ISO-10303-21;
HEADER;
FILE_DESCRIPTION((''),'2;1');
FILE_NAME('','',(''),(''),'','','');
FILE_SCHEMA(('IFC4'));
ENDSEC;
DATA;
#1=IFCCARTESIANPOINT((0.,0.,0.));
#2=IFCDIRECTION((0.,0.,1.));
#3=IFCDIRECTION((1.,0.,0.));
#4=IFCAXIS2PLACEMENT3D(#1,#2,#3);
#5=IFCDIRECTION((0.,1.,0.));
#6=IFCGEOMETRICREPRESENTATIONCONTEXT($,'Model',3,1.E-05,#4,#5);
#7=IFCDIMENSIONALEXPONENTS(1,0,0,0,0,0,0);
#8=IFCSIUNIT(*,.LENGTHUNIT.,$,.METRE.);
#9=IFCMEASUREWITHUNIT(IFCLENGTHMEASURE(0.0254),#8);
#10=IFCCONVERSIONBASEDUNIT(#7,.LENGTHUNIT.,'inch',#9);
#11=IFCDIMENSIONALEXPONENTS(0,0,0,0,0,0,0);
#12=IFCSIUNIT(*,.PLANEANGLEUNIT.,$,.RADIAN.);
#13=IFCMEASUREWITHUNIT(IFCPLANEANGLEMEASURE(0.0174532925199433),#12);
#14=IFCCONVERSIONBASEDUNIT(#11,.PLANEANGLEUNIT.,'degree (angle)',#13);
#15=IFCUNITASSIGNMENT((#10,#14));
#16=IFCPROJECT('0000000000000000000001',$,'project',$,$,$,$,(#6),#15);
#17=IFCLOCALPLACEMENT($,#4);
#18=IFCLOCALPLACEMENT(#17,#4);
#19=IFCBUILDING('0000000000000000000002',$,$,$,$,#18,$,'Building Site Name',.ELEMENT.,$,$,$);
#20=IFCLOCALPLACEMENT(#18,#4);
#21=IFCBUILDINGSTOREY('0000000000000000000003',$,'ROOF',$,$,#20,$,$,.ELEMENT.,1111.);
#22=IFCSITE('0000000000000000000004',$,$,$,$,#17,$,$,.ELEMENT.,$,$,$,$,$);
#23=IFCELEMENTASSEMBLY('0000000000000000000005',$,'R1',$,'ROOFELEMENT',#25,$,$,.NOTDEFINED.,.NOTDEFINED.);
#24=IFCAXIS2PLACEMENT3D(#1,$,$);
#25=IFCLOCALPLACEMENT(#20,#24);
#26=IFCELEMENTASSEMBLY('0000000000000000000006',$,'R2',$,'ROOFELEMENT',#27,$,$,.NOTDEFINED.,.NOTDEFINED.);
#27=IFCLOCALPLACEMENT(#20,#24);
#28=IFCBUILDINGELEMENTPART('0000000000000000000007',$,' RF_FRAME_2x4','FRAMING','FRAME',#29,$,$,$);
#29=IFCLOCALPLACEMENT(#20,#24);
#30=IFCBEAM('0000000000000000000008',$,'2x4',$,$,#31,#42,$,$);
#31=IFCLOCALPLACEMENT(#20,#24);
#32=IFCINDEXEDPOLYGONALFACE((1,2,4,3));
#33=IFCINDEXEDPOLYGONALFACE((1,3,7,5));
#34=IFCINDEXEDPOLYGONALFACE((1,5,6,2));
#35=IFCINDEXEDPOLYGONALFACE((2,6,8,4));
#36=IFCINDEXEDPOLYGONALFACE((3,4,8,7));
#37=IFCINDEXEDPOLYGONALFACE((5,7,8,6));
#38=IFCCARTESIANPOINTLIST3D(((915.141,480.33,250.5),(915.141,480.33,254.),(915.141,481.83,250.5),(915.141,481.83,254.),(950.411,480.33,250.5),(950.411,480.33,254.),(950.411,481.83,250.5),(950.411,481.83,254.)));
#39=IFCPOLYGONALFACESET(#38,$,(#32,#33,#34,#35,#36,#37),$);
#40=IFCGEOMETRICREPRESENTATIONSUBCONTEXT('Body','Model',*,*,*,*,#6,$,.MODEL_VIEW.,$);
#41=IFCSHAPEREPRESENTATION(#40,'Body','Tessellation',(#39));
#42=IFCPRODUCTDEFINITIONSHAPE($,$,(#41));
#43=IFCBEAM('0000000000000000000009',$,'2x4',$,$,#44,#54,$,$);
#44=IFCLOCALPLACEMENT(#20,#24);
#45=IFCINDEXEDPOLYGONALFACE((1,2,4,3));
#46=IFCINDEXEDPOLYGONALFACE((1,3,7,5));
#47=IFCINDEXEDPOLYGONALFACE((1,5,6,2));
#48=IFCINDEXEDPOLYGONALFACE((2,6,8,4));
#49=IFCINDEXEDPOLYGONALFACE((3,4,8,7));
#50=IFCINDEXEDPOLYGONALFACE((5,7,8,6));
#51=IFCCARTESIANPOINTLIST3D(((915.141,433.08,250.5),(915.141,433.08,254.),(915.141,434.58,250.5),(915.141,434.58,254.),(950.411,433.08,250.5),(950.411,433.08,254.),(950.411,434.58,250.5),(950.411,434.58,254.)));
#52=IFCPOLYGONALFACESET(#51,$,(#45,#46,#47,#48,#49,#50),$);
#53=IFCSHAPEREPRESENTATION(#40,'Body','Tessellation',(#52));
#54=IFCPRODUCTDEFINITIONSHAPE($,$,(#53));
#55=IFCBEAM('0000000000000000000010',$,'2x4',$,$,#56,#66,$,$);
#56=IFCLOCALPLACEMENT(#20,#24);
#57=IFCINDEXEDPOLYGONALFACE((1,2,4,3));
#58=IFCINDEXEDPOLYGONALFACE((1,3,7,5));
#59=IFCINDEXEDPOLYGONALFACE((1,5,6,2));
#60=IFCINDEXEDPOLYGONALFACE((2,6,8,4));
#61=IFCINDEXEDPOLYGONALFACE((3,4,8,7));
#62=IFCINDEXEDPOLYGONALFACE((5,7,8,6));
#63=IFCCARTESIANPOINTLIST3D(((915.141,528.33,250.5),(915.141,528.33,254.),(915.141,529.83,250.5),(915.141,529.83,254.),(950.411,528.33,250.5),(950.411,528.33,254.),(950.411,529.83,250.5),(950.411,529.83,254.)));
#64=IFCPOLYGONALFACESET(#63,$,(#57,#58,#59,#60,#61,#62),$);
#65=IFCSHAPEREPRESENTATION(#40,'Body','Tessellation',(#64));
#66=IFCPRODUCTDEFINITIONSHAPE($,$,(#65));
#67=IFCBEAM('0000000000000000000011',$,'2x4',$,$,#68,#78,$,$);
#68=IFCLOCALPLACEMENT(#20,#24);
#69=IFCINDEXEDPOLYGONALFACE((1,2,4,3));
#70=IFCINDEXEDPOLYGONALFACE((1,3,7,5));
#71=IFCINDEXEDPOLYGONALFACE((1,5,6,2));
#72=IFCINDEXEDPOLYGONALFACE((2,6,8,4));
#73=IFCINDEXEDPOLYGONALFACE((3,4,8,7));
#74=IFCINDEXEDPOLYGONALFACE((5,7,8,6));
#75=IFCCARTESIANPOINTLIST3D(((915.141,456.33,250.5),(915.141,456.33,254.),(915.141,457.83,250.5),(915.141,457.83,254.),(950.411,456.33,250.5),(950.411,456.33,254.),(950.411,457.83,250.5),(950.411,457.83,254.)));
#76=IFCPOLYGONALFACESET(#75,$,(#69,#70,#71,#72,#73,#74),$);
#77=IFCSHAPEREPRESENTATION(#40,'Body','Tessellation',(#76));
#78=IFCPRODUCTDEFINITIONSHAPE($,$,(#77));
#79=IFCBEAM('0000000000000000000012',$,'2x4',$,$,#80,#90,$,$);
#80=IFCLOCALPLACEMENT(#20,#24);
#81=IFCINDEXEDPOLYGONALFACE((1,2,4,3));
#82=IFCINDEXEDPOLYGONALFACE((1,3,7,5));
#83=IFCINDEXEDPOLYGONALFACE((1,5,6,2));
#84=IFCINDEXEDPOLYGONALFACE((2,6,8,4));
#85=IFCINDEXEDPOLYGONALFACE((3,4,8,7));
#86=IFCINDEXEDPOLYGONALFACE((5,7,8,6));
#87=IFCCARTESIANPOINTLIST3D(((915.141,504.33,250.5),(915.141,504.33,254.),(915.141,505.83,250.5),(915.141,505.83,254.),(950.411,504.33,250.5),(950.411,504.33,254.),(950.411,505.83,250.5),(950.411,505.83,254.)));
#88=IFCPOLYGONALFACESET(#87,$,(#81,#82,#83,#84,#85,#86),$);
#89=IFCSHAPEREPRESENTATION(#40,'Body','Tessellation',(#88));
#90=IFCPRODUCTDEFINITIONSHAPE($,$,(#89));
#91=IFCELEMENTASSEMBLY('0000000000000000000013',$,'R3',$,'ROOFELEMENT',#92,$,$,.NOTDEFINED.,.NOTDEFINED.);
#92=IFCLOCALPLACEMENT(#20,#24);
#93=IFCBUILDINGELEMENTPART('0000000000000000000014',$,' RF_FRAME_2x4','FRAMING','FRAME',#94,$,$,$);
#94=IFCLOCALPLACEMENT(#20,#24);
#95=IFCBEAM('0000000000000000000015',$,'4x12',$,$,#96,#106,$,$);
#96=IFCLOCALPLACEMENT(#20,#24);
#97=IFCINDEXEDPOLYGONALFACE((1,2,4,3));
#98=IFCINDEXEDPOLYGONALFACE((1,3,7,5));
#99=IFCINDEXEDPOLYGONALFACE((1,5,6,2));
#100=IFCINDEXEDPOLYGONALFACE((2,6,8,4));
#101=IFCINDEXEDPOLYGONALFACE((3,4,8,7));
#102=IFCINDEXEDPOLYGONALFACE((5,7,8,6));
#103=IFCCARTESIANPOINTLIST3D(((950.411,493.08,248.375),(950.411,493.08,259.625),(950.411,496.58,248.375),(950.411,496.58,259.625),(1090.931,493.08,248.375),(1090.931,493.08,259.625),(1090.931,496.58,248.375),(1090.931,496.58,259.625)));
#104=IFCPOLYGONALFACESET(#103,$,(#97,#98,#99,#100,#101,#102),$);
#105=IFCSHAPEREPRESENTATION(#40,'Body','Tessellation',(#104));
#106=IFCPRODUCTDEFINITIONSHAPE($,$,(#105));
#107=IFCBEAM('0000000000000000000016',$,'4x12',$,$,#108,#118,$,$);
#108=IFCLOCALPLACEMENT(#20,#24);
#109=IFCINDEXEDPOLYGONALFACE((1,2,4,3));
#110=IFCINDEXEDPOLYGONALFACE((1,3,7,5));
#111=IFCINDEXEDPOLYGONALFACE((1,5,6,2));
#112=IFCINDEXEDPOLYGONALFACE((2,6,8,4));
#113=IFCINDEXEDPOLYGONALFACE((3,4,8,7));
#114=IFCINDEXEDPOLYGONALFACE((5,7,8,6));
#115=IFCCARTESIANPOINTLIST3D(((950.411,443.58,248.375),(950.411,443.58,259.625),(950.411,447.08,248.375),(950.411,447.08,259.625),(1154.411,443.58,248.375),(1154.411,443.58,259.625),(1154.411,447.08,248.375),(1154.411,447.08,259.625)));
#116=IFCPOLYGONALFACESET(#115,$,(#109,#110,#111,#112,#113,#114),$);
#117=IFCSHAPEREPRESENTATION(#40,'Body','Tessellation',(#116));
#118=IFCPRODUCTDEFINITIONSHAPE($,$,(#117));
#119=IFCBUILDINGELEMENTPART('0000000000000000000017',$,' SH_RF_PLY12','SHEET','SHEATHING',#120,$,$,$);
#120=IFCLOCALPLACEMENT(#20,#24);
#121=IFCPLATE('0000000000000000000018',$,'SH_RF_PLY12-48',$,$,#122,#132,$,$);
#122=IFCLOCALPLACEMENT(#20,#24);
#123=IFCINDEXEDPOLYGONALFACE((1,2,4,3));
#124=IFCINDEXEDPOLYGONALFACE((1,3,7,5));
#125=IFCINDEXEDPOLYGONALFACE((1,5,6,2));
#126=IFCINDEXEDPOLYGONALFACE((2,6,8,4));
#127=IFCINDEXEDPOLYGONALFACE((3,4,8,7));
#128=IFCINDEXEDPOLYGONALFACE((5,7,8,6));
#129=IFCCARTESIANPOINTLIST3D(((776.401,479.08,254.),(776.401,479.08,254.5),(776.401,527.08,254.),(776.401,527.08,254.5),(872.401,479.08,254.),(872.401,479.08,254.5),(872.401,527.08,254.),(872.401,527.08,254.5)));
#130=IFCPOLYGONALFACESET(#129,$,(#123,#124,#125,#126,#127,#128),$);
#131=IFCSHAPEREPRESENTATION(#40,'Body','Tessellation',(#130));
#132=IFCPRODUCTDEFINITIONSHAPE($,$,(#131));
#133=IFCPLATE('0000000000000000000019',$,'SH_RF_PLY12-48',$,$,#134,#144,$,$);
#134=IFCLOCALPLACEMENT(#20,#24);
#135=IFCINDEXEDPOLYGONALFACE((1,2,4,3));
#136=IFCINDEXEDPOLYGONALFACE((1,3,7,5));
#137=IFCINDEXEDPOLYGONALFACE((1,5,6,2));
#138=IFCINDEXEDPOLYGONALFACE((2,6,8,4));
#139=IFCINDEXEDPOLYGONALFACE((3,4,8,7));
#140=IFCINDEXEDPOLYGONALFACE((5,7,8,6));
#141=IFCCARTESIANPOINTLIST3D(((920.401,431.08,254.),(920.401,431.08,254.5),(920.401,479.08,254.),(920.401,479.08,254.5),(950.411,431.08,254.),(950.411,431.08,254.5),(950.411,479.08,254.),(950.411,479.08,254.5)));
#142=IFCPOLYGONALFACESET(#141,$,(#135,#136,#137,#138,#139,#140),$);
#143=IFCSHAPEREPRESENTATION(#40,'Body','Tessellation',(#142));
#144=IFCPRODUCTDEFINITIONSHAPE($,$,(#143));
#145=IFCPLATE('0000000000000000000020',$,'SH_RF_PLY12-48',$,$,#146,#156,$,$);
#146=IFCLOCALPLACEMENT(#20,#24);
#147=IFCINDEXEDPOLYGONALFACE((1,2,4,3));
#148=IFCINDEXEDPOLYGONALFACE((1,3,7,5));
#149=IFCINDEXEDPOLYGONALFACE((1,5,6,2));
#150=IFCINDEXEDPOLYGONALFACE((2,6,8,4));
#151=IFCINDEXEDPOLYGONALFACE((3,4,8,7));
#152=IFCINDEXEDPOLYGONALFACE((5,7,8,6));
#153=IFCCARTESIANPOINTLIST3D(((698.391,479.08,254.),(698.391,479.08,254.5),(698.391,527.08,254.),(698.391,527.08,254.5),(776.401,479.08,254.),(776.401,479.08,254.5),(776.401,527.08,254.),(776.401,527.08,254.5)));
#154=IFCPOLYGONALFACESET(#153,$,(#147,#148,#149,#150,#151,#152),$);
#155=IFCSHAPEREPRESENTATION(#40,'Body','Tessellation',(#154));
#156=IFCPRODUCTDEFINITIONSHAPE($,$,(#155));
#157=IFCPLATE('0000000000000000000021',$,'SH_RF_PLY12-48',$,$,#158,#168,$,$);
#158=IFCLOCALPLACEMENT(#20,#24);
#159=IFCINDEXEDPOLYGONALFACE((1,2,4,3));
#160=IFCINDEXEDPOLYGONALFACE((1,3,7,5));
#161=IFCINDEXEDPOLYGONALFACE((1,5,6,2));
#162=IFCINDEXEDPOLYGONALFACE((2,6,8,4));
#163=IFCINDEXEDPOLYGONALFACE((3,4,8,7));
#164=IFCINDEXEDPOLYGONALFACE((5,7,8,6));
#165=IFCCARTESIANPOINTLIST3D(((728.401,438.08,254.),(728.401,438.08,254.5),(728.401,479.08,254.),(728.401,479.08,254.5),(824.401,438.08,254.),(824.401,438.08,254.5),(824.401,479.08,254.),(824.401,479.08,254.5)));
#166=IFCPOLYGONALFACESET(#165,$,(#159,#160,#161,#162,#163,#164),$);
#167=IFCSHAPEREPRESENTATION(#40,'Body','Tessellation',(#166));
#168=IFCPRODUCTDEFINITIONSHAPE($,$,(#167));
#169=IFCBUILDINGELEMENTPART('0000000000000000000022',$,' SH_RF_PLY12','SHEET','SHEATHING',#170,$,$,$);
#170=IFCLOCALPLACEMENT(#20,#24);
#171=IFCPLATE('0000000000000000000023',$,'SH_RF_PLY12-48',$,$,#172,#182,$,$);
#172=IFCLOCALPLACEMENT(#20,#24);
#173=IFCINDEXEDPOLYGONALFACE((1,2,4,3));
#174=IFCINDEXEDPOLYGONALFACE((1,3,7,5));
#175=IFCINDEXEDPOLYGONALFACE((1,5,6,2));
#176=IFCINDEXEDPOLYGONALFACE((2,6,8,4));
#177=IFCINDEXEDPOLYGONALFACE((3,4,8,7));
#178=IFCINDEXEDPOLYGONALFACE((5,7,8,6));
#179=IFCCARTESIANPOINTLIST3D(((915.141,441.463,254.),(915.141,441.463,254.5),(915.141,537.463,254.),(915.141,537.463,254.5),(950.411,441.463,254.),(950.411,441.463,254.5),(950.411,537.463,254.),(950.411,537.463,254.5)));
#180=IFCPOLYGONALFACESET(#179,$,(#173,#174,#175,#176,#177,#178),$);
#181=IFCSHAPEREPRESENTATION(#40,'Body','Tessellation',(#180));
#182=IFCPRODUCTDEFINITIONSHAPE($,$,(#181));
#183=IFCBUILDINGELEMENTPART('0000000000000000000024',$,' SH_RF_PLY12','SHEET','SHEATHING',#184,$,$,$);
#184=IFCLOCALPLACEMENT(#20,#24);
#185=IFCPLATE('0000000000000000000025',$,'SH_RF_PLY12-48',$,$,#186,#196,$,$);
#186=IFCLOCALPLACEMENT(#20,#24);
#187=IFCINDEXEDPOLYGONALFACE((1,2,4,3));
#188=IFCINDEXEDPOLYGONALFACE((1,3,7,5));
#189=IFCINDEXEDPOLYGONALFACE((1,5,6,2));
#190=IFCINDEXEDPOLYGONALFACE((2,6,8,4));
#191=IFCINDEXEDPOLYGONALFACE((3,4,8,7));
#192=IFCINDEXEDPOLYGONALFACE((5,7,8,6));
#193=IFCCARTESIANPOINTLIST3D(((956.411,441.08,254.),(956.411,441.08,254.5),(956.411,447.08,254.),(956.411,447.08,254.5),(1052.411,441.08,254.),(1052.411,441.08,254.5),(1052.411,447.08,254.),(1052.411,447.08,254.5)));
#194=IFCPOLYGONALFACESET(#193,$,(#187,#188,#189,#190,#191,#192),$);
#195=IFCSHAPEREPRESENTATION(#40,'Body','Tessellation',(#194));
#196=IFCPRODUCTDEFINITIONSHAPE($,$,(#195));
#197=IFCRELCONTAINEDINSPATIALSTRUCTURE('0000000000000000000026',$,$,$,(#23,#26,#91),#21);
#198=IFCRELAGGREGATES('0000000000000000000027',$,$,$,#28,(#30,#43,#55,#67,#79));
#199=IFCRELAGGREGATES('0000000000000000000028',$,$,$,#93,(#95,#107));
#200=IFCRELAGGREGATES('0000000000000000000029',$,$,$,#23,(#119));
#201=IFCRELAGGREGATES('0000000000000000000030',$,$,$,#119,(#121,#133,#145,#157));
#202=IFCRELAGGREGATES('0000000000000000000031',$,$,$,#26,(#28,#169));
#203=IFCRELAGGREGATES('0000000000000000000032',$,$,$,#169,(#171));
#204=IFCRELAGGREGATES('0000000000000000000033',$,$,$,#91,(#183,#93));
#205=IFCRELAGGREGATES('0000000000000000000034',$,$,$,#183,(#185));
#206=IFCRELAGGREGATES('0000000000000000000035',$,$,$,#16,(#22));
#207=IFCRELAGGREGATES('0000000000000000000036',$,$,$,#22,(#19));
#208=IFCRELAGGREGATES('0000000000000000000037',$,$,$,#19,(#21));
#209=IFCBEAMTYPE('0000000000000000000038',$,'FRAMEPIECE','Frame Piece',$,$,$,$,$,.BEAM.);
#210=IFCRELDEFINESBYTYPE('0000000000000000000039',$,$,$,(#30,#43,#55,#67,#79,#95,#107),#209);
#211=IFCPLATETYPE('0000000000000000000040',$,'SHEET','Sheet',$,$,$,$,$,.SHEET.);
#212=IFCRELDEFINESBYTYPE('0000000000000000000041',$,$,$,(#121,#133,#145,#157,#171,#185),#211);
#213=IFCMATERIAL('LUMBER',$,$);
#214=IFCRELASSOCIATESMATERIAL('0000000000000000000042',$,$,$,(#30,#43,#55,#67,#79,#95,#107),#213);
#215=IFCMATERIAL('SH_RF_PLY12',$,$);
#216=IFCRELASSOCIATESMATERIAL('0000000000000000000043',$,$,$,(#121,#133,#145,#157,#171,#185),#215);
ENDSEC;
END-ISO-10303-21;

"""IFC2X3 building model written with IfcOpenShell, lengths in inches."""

from ifc_helpers import new_model, entity, si_unit, converted_unit, direction, frame, frame_2d, origin_with_axes, place, context, subcontext, project, spatial, rectangle, extrude, material, type_object, element, aggregate, save


model = new_model("IFC2X3")

# Units and contexts
model_context = context("Model", 3, precision=1e-05, world=origin_with_axes(), true_north=direction((0.0, 1.0, 0.0)))
body_context = subcontext(model_context, "Body", "Model", "MODEL_VIEW")
ifc_project = project(units=[converted_unit("LENGTHUNIT", "inch", entity("IfcLengthMeasure", 0.0254), si_unit("LENGTHUNIT", "METRE"), dimensions=[1, 0, 0, 0, 0, 0, 0]), converted_unit("PLANEANGLEUNIT", "degree (angle)", entity("IfcPlaneAngleMeasure", 0.0174532925199433), si_unit("PLANEANGLEUNIT", "RADIAN"), dimensions=[0, 0, 0, 0, 0, 0, 0])], contexts=[model_context])

# Site, building, storey
site_placement = place(None, origin_with_axes())
site = spatial("IfcSite", under=ifc_project, at=site_placement, CompositionType="ELEMENT")
building_placement = place(site_placement, origin_with_axes())
building = spatial("IfcBuilding", under=site, at=building_placement, LongName="Building Site Name", CompositionType="ELEMENT")
storey_placement = place(building_placement, origin_with_axes())
storey = spatial("IfcBuildingStorey", under=building, at=storey_placement, Name="ROOF", CompositionType="ELEMENT", Elevation=1111.0)

# Element assemblies, building element parts, beams
assembly_1_placement = place(storey_placement, origin_with_axes())
assembly_1 = element("IfcElementAssembly", 1, at=assembly_1_placement, inside=storey, Name="R1", ObjectType="ROOFELEMENT", AssemblyPlace="NOTDEFINED", PredefinedType="NOTDEFINED")
ifc_material_1 = material(Name="LUMBER")
beam_type = type_object("IfcBeamType", Name="FRAMEPIECE", Description="Frame Piece", PredefinedType="BEAM")
assembly_2_placement = place(storey_placement, origin_with_axes())
assembly_2 = element("IfcElementAssembly", 2, at=assembly_2_placement, inside=storey, Name="R2", ObjectType="ROOFELEMENT", AssemblyPlace="NOTDEFINED", PredefinedType="NOTDEFINED")
building_element_part_1 = element("IfcBuildingElementPart", 3, Name=" RF_FRAME_2x4", Description="FRAMING", ObjectType="FRAME")
beam_1_placement = place(assembly_2_placement, frame((950.411, 481.08, 252.25), z_axis=(-1.0, 0.0, 0.0), x_axis=(0.0, -1.0, 0.0)))
beam_1 = element("IfcBeam", 4, at=beam_1_placement, type_object=beam_type, material=ifc_material_1, Name="2x4", context=body_context, shape_type="SweptSolid", body=[
    extrude(rectangle(XDim=1.5, YDim=3.5, at=frame_2d((0.0, 0.0), x_axis=(-1.0, 0.0))), origin_with_axes(), (0.0, 0.0, 1.0), 35.27),
])
beam_2_placement = place(assembly_2_placement, frame((950.411, 433.83, 252.25), z_axis=(-1.0, 0.0, 0.0), x_axis=(0.0, -1.0, 0.0)))
beam_2 = element("IfcBeam", 5, at=beam_2_placement, type_object=beam_type, material=ifc_material_1, Name="2x4", context=body_context, shape_type="SweptSolid", body=[
    extrude(rectangle(XDim=1.5, YDim=3.5, at=frame_2d((0.0, 0.0), x_axis=(-1.0, 0.0))), origin_with_axes(), (0.0, 0.0, 1.0), 35.27),
])
beam_3_placement = place(assembly_2_placement, frame((950.411, 529.08, 252.25), z_axis=(-1.0, 0.0, 0.0), x_axis=(0.0, -1.0, 0.0)))
beam_3 = element("IfcBeam", 6, at=beam_3_placement, type_object=beam_type, material=ifc_material_1, Name="2x4", context=body_context, shape_type="SweptSolid", body=[
    extrude(rectangle(XDim=1.5, YDim=3.5, at=frame_2d((0.0, 0.0), x_axis=(-1.0, 0.0))), origin_with_axes(), (0.0, 0.0, 1.0), 35.27),
])
beam_4_placement = place(assembly_2_placement, frame((950.411, 457.08, 252.25), z_axis=(-1.0, 0.0, 0.0), x_axis=(0.0, -1.0, 0.0)))
beam_4 = element("IfcBeam", 7, at=beam_4_placement, type_object=beam_type, material=ifc_material_1, Name="2x4", context=body_context, shape_type="SweptSolid", body=[
    extrude(rectangle(XDim=1.5, YDim=3.5, at=frame_2d((0.0, 0.0), x_axis=(-1.0, 0.0))), origin_with_axes(), (0.0, 0.0, 1.0), 35.27),
])
beam_5_placement = place(assembly_2_placement, frame((950.411, 505.08, 252.25), z_axis=(-1.0, 0.0, 0.0), x_axis=(0.0, -1.0, 0.0)))
beam_5 = element("IfcBeam", 8, at=beam_5_placement, type_object=beam_type, material=ifc_material_1, Name="2x4", context=body_context, shape_type="SweptSolid", body=[
    extrude(rectangle(XDim=1.5, YDim=3.5, at=frame_2d((0.0, 0.0), x_axis=(-1.0, 0.0))), origin_with_axes(), (0.0, 0.0, 1.0), 35.27),
])
aggregate(building_element_part_1, [beam_1, beam_2, beam_3, beam_4, beam_5])
assembly_3_placement = place(storey_placement, origin_with_axes())
assembly_3 = element("IfcElementAssembly", 9, at=assembly_3_placement, inside=storey, Name="R3", ObjectType="ROOFELEMENT", AssemblyPlace="NOTDEFINED", PredefinedType="NOTDEFINED")
building_element_part_2 = element("IfcBuildingElementPart", 10, Name=" RF_FRAME_2x4", Description="FRAMING", ObjectType="FRAME")
beam_6_placement = place(assembly_3_placement, frame((950.411, 494.83, 254.0), z_axis=(1.0, 0.0, 0.0), x_axis=(0.0, 1.0, 0.0)))
beam_6 = element("IfcBeam", 11, at=beam_6_placement, type_object=beam_type, material=ifc_material_1, Name="4x12", context=body_context, shape_type="SweptSolid", body=[
    extrude(rectangle(XDim=3.5, YDim=11.25, at=frame_2d((0.0, 0.0), x_axis=(-1.0, 0.0))), origin_with_axes(), (0.0, 0.0, 1.0), 140.52),
])
beam_7_placement = place(assembly_3_placement, frame((950.411, 445.33, 254.0), z_axis=(1.0, 0.0, 0.0), x_axis=(0.0, 1.0, 0.0)))
beam_7 = element("IfcBeam", 12, at=beam_7_placement, type_object=beam_type, material=ifc_material_1, Name="4x12", context=body_context, shape_type="SweptSolid", body=[
    extrude(rectangle(XDim=3.5, YDim=11.25, at=frame_2d((0.0, 0.0), x_axis=(-1.0, 0.0))), origin_with_axes(), (0.0, 0.0, 1.0), 204.0),
])
aggregate(building_element_part_2, [beam_6, beam_7])

# Building element part
building_element_part_3 = element("IfcBuildingElementPart", 13, Name=" SH_RF_PLY12", Description="SHEET", ObjectType="SHEATHING")
aggregate(assembly_1, [building_element_part_3])

# Plates
ifc_material_2 = material(Name="SH_RF_PLY12")
plate_type = type_object("IfcPlateType", Name="SHEET", Description="Sheet", PredefinedType="SHEET")
plate_1_placement = place(assembly_1_placement, frame((824.401, 503.08, 254.5), z_axis=(0.0, 0.0, 1.0), x_axis=(0.0, 1.0, 0.0)))
plate_1 = element("IfcPlate", 14, at=plate_1_placement, type_object=plate_type, material=ifc_material_2, Name="SH_RF_PLY12-48", context=body_context, shape_type="SweptSolid", body=[
    extrude(rectangle(XDim=0.5, YDim=48.0, at=frame_2d((0.0, -0.25), x_axis=(0.0, -1.0))), frame((0.0, -48.0, 0.0), z_axis=(0.0, 1.0, 0.0), x_axis=(-1.0, 0.0, 0.0)), (0.0, 0.0, 1.0), 96.0),
])
plate_2_placement = place(assembly_1_placement, frame((968.401, 455.08, 254.5), z_axis=(0.0, 0.0, 1.0), x_axis=(0.0, 1.0, 0.0)))
plate_2 = element("IfcPlate", 15, at=plate_2_placement, type_object=plate_type, material=ifc_material_2, Name="SH_RF_PLY12-48", context=body_context, shape_type="SweptSolid", body=[
    extrude(rectangle(XDim=0.5, YDim=48.0, at=frame_2d((0.0, -0.25), x_axis=(0.0, -1.0))), frame((0.0, 17.99, 0.0), z_axis=(0.0, 1.0, 0.0), x_axis=(-1.0, 0.0, 0.0)), (0.0, 0.0, 1.0), 30.01),
])
plate_3_placement = place(assembly_1_placement, frame((728.401, 503.08, 254.5), z_axis=(0.0, 0.0, 1.0), x_axis=(0.0, 1.0, 0.0)))
plate_3 = element("IfcPlate", 16, at=plate_3_placement, type_object=plate_type, material=ifc_material_2, Name="SH_RF_PLY12-48", context=body_context, shape_type="SweptSolid", body=[
    extrude(rectangle(XDim=0.5, YDim=48.0, at=frame_2d((0.0, -0.25), x_axis=(0.0, -1.0))), frame((0.0, -48.0, 0.0), z_axis=(0.0, 1.0, 0.0), x_axis=(-1.0, 0.0, 0.0)), (0.0, 0.0, 1.0), 78.01),
])
plate_4_placement = place(assembly_1_placement, frame((776.401, 455.08, 254.5), z_axis=(0.0, 0.0, 1.0), x_axis=(0.0, 1.0, 0.0)))
plate_4 = element("IfcPlate", 17, at=plate_4_placement, type_object=plate_type, material=ifc_material_2, Name="SH_RF_PLY12-48", context=body_context, shape_type="SweptSolid", body=[
    extrude(rectangle(XDim=0.5, YDim=41.0, at=frame_2d((-3.5, -0.25), x_axis=(0.0, -1.0))), frame((0.0, -48.0, 0.0), z_axis=(0.0, 1.0, 0.0), x_axis=(-1.0, 0.0, 0.0)), (0.0, 0.0, 1.0), 96.0),
])
aggregate(building_element_part_3, [plate_1, plate_2, plate_3, plate_4])

# Building element part
building_element_part_4 = element("IfcBuildingElementPart", 18, Name=" SH_RF_PLY12", Description="SHEET", ObjectType="SHEATHING")
aggregate(assembly_2, [building_element_part_1, building_element_part_4])

# Plate
plate_5_placement = place(assembly_2_placement, frame((939.141, 489.463, 254.5), z_axis=(0.0, 0.0, 1.0), x_axis=(-1.0, 0.0, 0.0)))
plate_5 = element("IfcPlate", 19, at=plate_5_placement, type_object=plate_type, material=ifc_material_2, Name="SH_RF_PLY12-48", context=body_context, shape_type="SweptSolid", body=[
    extrude(rectangle(XDim=0.5, YDim=35.27, at=frame_2d((-6.365, -0.25), x_axis=(0.0, -1.0))), frame((0.0, -48.0, 0.0), z_axis=(0.0, 1.0, 0.0), x_axis=(-1.0, 0.0, 0.0)), (0.0, 0.0, 1.0), 96.0),
])
aggregate(building_element_part_4, [plate_5])

# Building element part
building_element_part_5 = element("IfcBuildingElementPart", 20, Name=" SH_RF_PLY12", Description="SHEET", ObjectType="SHEATHING")
aggregate(assembly_3, [building_element_part_5, building_element_part_2])

# Plate
plate_6_placement = place(assembly_3_placement, frame((1004.411, 465.08, 254.5), z_axis=(0.0, 0.0, 1.0), x_axis=(0.0, 1.0, 0.0)))
plate_6 = element("IfcPlate", 21, at=plate_6_placement, type_object=plate_type, material=ifc_material_2, Name="SH_RF_PLY12-48", context=body_context, shape_type="SweptSolid", body=[
    extrude(rectangle(XDim=0.5, YDim=6.0, at=frame_2d((21.0, -0.25), x_axis=(0.0, -1.0))), frame((0.0, -48.0, 0.0), z_axis=(0.0, 1.0, 0.0), x_axis=(-1.0, 0.0, 0.0)), (0.0, 0.0, 1.0), 96.0),
])
aggregate(building_element_part_5, [plate_6])

save(model, "model.ifc")
